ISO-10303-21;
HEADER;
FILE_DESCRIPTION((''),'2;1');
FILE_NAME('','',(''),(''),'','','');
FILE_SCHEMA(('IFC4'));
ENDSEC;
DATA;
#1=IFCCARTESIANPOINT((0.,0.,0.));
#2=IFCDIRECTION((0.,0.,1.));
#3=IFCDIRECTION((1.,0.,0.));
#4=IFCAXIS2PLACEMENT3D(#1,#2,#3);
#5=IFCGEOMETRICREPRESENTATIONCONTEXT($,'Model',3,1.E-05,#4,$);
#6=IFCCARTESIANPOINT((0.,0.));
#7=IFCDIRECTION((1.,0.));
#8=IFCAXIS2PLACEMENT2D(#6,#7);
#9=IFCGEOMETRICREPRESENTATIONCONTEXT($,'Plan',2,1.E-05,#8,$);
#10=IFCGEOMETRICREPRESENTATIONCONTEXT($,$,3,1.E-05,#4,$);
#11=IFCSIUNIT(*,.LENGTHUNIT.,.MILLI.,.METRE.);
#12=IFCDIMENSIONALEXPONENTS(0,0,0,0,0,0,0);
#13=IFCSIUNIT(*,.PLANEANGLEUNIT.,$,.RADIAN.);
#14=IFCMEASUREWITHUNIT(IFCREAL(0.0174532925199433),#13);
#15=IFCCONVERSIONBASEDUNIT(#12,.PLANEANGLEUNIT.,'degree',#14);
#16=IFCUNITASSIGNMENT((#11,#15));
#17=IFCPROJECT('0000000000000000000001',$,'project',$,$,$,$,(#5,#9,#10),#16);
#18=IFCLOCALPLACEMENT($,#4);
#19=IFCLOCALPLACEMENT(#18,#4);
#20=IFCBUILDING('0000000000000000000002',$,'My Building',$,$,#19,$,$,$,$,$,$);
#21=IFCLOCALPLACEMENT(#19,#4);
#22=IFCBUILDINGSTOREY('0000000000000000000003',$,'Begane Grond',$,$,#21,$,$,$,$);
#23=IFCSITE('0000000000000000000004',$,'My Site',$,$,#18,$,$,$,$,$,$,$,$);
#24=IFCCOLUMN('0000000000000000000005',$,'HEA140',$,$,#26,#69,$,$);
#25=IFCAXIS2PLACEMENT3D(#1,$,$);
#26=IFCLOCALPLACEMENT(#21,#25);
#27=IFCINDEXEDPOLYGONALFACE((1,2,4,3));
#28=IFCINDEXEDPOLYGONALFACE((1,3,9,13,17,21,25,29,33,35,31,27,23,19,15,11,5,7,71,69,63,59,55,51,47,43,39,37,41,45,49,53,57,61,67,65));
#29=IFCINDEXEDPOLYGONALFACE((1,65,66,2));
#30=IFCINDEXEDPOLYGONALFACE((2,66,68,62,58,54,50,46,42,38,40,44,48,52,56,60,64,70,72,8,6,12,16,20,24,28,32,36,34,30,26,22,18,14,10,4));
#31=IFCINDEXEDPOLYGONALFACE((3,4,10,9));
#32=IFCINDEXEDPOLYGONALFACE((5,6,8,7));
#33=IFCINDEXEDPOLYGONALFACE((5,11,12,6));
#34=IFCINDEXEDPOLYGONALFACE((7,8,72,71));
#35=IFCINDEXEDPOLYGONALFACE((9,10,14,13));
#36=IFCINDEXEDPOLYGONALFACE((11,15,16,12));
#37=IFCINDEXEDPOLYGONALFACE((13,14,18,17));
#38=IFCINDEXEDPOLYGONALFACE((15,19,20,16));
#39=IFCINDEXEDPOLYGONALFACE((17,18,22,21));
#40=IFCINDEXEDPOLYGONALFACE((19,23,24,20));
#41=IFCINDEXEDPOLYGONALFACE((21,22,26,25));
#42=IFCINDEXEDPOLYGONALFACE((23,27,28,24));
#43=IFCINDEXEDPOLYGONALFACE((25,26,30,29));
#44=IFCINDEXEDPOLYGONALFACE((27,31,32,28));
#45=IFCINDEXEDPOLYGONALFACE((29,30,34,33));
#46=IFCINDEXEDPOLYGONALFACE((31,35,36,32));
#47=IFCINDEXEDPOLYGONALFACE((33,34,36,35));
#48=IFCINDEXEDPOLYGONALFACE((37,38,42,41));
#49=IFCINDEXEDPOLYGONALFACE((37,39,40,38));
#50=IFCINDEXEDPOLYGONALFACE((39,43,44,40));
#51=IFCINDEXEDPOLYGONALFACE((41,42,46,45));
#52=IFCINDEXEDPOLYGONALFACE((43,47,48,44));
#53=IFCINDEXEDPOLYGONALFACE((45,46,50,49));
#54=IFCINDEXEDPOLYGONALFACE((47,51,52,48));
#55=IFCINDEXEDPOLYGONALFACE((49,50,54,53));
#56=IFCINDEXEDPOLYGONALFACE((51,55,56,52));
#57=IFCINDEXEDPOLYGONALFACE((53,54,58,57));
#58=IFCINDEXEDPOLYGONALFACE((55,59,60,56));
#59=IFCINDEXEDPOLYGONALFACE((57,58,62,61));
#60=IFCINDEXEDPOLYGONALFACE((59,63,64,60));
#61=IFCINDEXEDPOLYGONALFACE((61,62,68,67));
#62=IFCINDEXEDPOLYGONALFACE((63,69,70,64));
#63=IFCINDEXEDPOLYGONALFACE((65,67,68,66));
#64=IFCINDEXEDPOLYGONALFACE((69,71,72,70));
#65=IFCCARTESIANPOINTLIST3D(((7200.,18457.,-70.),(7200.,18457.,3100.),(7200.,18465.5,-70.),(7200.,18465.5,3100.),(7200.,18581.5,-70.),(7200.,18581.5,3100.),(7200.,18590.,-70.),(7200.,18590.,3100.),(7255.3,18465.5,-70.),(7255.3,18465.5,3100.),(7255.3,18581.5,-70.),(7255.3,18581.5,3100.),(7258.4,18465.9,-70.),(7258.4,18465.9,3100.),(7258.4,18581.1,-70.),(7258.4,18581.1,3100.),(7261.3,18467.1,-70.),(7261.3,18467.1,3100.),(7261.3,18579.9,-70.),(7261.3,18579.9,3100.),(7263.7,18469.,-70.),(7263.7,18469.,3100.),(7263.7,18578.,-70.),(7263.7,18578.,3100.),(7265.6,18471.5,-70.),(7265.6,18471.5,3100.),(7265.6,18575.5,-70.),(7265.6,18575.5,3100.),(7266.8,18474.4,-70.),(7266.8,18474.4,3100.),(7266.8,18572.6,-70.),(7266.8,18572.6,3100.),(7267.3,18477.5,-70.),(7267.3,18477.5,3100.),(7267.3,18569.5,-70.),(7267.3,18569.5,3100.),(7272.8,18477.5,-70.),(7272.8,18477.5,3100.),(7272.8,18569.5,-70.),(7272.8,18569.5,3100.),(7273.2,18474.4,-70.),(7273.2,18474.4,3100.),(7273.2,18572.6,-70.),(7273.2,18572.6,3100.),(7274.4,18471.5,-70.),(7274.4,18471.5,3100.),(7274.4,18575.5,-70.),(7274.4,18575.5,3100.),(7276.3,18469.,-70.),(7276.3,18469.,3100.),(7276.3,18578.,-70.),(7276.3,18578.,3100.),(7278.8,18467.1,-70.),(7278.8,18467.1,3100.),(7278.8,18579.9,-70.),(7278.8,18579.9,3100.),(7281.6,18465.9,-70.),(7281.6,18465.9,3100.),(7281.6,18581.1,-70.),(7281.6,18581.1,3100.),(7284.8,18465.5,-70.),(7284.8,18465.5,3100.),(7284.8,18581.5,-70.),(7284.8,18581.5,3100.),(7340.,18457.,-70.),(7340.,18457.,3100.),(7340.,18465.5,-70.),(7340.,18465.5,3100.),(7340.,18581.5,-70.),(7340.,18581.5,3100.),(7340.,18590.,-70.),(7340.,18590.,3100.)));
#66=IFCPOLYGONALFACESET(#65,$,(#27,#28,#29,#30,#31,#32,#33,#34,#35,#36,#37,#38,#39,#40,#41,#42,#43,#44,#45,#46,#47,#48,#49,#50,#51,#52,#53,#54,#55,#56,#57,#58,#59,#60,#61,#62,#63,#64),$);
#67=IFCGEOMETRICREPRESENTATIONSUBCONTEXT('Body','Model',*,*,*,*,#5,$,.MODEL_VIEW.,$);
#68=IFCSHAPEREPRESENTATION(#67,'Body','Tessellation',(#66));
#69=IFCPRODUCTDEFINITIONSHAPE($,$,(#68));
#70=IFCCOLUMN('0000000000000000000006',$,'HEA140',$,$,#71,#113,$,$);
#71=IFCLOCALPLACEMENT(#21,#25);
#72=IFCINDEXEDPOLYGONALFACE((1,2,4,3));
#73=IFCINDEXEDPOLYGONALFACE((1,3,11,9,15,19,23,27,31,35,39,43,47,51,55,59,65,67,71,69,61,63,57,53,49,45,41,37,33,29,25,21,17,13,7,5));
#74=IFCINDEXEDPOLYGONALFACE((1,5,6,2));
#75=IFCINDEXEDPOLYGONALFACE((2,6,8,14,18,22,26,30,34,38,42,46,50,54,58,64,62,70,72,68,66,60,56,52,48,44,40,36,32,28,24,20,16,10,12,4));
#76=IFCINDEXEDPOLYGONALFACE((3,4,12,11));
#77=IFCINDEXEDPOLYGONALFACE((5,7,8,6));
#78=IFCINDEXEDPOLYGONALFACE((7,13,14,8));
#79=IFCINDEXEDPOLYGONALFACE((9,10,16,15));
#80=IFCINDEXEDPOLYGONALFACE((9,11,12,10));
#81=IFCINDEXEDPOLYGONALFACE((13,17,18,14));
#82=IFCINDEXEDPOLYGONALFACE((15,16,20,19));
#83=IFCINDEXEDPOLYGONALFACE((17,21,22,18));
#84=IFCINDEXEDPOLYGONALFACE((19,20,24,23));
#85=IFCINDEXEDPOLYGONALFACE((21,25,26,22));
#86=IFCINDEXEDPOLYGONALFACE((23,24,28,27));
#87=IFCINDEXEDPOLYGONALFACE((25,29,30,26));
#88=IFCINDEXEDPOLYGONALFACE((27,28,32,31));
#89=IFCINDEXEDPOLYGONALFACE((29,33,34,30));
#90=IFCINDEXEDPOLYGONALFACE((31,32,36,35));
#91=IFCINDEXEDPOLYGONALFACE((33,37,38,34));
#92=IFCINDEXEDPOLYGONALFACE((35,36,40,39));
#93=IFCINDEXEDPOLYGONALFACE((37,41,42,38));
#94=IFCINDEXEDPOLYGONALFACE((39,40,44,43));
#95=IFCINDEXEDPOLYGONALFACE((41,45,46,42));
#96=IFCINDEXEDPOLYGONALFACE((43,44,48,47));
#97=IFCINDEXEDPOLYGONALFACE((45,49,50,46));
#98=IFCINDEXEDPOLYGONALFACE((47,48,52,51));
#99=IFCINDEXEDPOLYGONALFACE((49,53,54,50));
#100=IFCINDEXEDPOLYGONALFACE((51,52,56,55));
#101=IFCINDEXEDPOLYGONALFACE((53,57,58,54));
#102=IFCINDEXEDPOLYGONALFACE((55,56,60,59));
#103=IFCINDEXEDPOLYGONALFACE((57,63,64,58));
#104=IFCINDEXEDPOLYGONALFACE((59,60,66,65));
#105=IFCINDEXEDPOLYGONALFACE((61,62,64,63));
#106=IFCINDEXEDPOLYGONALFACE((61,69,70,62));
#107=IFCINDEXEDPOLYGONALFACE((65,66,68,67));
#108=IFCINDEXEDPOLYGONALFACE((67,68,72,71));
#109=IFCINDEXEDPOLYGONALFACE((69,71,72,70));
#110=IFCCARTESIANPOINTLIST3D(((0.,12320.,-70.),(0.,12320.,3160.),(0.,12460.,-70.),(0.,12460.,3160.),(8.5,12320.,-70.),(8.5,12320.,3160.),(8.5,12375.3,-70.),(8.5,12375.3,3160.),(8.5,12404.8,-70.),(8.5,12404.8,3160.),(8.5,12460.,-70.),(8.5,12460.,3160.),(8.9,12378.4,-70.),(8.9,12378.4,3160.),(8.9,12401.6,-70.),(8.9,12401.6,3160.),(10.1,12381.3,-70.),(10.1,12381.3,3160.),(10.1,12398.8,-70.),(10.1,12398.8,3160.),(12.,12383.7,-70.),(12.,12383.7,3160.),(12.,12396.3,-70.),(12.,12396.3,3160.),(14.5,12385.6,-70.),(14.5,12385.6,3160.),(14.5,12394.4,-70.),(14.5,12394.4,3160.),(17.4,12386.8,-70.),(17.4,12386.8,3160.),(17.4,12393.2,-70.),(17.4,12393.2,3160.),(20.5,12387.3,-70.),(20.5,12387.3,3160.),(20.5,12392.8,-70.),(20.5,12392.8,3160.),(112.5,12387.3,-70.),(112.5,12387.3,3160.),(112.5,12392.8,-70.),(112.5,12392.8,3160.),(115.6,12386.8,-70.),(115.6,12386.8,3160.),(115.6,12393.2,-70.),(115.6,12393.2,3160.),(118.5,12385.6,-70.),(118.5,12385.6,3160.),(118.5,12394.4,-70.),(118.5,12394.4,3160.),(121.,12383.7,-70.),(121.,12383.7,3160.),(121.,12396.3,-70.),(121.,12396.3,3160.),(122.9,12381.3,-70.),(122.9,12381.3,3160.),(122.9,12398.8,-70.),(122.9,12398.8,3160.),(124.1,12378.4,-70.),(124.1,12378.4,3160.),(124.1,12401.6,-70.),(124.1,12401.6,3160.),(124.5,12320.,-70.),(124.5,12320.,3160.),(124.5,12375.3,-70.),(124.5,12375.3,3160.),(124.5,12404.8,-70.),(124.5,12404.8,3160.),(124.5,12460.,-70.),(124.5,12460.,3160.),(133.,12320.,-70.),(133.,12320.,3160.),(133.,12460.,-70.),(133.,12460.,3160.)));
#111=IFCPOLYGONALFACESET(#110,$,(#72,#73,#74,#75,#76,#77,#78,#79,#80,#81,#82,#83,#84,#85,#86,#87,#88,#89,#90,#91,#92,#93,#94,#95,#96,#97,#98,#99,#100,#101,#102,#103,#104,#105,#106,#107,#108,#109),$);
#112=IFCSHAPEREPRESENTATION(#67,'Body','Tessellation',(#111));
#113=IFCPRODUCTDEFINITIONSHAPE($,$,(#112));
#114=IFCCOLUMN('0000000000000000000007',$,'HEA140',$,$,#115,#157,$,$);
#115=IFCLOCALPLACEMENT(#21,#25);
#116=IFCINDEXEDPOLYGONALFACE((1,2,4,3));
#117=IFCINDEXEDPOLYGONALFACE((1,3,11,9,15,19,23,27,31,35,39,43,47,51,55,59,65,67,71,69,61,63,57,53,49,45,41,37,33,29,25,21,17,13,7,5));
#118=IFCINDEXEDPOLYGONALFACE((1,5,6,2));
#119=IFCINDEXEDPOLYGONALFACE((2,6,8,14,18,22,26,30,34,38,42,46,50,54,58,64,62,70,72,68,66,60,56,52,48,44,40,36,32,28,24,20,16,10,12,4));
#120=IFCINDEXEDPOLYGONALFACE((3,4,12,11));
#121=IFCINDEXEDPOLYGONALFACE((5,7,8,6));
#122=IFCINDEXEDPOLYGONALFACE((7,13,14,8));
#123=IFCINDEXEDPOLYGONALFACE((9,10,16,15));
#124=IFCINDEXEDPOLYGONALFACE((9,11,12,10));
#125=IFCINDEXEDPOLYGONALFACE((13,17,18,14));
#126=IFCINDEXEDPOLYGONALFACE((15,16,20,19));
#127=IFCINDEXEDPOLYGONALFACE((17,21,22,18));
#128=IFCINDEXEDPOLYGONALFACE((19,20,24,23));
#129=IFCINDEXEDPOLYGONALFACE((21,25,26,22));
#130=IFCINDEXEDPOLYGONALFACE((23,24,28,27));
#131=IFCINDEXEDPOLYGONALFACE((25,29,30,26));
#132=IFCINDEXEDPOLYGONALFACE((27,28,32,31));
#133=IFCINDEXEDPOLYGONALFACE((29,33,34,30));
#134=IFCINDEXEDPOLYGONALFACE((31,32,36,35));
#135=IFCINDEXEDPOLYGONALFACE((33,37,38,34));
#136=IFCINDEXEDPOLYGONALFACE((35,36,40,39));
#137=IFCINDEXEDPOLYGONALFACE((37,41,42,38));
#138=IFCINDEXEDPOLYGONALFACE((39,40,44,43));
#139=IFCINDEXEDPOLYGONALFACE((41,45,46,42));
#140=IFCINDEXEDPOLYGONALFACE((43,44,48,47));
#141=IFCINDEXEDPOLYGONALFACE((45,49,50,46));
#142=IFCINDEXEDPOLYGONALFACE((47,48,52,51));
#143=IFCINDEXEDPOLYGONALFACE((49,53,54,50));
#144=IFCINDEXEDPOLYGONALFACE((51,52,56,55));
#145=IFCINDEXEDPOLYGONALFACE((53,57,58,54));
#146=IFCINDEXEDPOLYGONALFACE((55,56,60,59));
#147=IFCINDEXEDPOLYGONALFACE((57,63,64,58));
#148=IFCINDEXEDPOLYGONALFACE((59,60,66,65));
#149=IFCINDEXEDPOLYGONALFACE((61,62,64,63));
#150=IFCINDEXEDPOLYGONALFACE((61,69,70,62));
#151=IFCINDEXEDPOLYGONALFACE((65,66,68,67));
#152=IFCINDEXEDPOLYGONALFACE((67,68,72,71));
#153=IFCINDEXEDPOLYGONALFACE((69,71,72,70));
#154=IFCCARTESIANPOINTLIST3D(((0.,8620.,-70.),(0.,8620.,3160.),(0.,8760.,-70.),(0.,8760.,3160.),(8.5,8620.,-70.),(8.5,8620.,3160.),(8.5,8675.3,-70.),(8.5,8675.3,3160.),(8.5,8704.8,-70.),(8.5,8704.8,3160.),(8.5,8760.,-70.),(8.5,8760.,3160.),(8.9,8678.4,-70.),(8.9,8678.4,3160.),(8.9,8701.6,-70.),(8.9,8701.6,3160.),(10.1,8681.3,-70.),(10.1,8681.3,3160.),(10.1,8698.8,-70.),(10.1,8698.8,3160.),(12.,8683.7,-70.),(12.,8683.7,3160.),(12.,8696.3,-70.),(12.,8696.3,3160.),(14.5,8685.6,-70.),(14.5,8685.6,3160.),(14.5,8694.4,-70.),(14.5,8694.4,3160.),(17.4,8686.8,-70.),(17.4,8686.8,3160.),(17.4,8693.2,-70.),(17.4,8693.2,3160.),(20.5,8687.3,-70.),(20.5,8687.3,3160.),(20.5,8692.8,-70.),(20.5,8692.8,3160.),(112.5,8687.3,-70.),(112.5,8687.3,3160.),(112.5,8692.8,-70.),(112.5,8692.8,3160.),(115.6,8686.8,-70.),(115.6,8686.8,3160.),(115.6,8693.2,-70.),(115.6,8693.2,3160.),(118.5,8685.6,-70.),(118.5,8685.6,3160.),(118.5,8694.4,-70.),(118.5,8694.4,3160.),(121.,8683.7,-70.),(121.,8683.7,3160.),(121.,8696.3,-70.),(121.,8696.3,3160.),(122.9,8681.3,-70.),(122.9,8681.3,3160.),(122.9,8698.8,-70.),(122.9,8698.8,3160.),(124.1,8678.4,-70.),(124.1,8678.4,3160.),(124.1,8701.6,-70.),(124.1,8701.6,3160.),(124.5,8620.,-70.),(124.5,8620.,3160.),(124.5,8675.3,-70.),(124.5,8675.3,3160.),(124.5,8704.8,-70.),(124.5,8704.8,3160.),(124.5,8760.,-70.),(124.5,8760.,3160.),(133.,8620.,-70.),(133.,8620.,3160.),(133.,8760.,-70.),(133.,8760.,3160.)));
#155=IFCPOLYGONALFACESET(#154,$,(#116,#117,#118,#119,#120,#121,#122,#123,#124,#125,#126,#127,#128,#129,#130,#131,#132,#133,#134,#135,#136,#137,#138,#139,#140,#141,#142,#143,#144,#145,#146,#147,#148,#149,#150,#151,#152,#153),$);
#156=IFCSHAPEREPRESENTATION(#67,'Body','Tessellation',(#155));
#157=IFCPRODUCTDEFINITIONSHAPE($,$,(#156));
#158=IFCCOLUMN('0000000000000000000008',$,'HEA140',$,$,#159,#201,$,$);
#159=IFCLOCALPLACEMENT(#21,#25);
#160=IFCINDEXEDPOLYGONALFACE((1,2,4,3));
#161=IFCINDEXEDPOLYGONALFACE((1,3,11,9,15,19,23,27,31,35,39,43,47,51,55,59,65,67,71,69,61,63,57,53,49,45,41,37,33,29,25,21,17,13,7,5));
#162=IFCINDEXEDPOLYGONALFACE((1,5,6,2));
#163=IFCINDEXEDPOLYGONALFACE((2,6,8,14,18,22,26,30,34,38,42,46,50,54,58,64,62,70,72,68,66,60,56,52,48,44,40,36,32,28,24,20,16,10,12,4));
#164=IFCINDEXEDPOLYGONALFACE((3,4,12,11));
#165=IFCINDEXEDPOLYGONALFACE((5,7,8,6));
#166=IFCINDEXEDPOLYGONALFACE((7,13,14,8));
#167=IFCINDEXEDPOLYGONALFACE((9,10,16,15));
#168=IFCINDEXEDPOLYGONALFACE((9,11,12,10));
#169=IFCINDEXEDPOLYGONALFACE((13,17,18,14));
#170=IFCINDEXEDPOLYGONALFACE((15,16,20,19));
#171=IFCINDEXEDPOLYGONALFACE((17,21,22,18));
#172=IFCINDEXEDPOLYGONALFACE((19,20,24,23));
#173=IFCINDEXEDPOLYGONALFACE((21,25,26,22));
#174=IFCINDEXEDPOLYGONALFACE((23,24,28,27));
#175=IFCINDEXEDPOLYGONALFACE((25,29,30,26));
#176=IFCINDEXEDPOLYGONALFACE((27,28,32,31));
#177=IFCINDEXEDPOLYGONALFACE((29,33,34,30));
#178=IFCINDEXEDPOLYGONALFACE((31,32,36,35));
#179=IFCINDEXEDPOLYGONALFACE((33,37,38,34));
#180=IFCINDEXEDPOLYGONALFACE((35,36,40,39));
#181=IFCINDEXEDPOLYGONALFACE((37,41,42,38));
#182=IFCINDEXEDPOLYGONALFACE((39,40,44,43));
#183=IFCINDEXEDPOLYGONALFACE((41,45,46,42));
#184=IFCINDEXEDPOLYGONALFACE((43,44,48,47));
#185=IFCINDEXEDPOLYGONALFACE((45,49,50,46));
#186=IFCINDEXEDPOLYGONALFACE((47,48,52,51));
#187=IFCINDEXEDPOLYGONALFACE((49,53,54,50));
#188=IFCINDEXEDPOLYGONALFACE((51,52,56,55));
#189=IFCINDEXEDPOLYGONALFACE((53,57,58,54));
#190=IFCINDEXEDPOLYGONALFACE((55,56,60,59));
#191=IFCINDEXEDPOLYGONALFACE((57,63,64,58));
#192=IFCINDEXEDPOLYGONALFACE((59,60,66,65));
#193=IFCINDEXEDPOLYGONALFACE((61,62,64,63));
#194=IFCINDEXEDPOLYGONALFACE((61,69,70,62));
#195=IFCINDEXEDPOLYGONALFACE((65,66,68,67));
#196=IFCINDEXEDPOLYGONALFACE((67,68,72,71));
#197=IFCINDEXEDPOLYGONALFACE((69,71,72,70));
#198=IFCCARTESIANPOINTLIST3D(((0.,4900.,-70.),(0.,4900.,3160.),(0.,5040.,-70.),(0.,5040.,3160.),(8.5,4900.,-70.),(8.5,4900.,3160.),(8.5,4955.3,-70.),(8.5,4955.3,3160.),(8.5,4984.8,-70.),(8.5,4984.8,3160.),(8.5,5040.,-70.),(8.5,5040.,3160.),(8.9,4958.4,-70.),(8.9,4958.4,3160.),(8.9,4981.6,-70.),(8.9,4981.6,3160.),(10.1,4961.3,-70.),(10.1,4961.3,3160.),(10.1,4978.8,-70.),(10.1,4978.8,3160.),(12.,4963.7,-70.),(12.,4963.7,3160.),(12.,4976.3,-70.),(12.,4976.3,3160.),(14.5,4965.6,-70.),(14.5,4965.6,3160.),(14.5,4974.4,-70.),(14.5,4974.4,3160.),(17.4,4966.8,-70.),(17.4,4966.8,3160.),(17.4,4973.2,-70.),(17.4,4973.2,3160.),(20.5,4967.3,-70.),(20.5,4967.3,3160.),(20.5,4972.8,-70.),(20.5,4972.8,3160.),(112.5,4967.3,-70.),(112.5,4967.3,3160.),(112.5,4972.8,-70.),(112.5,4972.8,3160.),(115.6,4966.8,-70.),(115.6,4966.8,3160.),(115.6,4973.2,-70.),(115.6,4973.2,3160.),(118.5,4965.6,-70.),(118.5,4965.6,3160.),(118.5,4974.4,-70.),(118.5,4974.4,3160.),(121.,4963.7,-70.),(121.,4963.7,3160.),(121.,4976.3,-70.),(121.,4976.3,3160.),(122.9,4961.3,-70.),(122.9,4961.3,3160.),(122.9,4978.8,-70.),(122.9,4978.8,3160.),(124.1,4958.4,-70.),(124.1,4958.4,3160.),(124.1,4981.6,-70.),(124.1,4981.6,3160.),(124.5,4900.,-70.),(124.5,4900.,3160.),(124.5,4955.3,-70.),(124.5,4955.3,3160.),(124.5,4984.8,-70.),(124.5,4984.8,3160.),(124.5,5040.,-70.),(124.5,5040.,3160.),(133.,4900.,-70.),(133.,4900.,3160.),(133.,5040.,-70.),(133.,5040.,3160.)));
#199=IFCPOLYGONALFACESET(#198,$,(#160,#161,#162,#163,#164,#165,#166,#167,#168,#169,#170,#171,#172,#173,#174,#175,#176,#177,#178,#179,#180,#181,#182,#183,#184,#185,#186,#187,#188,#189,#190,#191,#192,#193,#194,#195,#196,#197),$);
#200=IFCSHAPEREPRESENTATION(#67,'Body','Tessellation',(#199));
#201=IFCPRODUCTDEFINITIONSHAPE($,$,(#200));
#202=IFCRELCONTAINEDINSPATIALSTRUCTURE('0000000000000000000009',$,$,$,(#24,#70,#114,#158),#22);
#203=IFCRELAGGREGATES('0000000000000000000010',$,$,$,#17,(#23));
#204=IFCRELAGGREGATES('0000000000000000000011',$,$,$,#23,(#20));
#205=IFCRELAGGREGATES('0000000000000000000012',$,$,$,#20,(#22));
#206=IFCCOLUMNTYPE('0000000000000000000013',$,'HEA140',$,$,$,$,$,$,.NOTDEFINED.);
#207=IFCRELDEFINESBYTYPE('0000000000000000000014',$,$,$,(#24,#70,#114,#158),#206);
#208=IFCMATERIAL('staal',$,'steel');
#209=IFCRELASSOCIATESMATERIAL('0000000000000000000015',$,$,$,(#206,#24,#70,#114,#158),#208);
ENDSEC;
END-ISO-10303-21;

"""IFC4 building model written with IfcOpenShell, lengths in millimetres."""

from ifc_helpers import new_model, entity, si_unit, converted_unit, frame, origin_with_axes, origin_2d_with_axis, place, context, subcontext, project, spatial, i_section, extrude, material, material_profile, profile_set, profile_usage, type_object, element, save


model = new_model("IFC4")

# Units and contexts
model_context = context("Model", 3, precision=1e-05, world=origin_with_axes())
plan_context = context("Plan", 2, precision=1e-05, world=origin_2d_with_axis())
context_of_model = context(None, 3, precision=1e-05, world=origin_with_axes())
body_context = subcontext(model_context, "Body", "Model", "MODEL_VIEW")
ifc_project = project(units=[si_unit("LENGTHUNIT", "METRE", prefix="MILLI"), converted_unit("PLANEANGLEUNIT", "degree", entity("IfcReal", 0.0174532925199433), si_unit("PLANEANGLEUNIT", "RADIAN"), dimensions=[0, 0, 0, 0, 0, 0, 0])], contexts=[model_context, plan_context, context_of_model])

# Site, building, storey
site_placement = place(None, origin_with_axes())
site = spatial("IfcSite", under=ifc_project, at=site_placement, Name="My Site")
building_placement = place(site_placement, origin_with_axes())
building = spatial("IfcBuilding", under=site, at=building_placement, Name="My Building")
storey_placement = place(building_placement, origin_with_axes())
storey = spatial("IfcBuildingStorey", under=building, at=storey_placement, Name="Begane Grond")

# Columns
ifc_material = material(Name="staal", Category="steel")
ifc_material_profile_1 = material_profile(ifc_material, i_section(OverallWidth=140.0, OverallDepth=133.0, WebThickness=5.5, FlangeThickness=8.5, FilletRadius=12.0))
ifc_profile_set_1 = profile_set([ifc_material_profile_1], Name="HEA140")
ifc_profile_usage_1 = profile_usage(ifc_profile_set_1)
column_type_1 = type_object("IfcColumnType", Name="HEA140", PredefinedType="NOTDEFINED", material=ifc_profile_set_1)
column_1_placement = place(storey_placement, frame((7270.0, 18523.5, -70.0), z_axis=(0.0, 0.0, 1.0), x_axis=(1.0, 0.0, 0.0)))
element("IfcColumn", 1, at=column_1_placement, inside=storey, type_object=column_type_1, material=ifc_profile_usage_1, Name="HEA140", context=body_context, shape_type="SweptSolid", body=[
    extrude(i_section(OverallWidth=140.0, OverallDepth=133.0, WebThickness=5.5, FlangeThickness=8.5, FilletRadius=12.0), origin_with_axes(), (0.0, 0.0, 1.0), 3170.0),
])
ifc_profile_usage_2 = profile_usage(ifc_profile_set_1)
column_2_placement = place(storey_placement, frame((66.5, 12390.0, -70.0), z_axis=(0.0, 0.0, 1.0), x_axis=(0.0, 1.0, 0.0)))
element("IfcColumn", 2, at=column_2_placement, inside=storey, type_object=column_type_1, material=ifc_profile_usage_2, Name="HEA140", context=body_context, shape_type="SweptSolid", body=[
    extrude(i_section(OverallWidth=140.0, OverallDepth=133.0, WebThickness=5.5, FlangeThickness=8.5, FilletRadius=12.0), origin_with_axes(), (0.0, 0.0, 1.0), 3230.0),
])
ifc_profile_usage_3 = profile_usage(ifc_profile_set_1)
column_3_placement = place(storey_placement, frame((66.5, 8690.0, -70.0), z_axis=(0.0, 0.0, 1.0), x_axis=(0.0, 1.0, 0.0)))
element("IfcColumn", 3, at=column_3_placement, inside=storey, type_object=column_type_1, material=ifc_profile_usage_3, Name="HEA140", context=body_context, shape_type="SweptSolid", body=[
    extrude(i_section(OverallWidth=140.0, OverallDepth=133.0, WebThickness=5.5, FlangeThickness=8.5, FilletRadius=12.0), origin_with_axes(), (0.0, 0.0, 1.0), 3230.0),
])
ifc_profile_usage_4 = profile_usage(ifc_profile_set_1)
column_4_placement = place(storey_placement, frame((66.5, 4970.0, -70.0), z_axis=(0.0, 0.0, 1.0), x_axis=(0.0, 1.0, 0.0)))
element("IfcColumn", 4, at=column_4_placement, inside=storey, type_object=column_type_1, material=ifc_profile_usage_4, Name="HEA140", context=body_context, shape_type="SweptSolid", body=[
    extrude(i_section(OverallWidth=140.0, OverallDepth=133.0, WebThickness=5.5, FlangeThickness=8.5, FilletRadius=12.0), origin_with_axes(), (0.0, 0.0, 1.0), 3230.0),
])

save(model, "model.ifc")
